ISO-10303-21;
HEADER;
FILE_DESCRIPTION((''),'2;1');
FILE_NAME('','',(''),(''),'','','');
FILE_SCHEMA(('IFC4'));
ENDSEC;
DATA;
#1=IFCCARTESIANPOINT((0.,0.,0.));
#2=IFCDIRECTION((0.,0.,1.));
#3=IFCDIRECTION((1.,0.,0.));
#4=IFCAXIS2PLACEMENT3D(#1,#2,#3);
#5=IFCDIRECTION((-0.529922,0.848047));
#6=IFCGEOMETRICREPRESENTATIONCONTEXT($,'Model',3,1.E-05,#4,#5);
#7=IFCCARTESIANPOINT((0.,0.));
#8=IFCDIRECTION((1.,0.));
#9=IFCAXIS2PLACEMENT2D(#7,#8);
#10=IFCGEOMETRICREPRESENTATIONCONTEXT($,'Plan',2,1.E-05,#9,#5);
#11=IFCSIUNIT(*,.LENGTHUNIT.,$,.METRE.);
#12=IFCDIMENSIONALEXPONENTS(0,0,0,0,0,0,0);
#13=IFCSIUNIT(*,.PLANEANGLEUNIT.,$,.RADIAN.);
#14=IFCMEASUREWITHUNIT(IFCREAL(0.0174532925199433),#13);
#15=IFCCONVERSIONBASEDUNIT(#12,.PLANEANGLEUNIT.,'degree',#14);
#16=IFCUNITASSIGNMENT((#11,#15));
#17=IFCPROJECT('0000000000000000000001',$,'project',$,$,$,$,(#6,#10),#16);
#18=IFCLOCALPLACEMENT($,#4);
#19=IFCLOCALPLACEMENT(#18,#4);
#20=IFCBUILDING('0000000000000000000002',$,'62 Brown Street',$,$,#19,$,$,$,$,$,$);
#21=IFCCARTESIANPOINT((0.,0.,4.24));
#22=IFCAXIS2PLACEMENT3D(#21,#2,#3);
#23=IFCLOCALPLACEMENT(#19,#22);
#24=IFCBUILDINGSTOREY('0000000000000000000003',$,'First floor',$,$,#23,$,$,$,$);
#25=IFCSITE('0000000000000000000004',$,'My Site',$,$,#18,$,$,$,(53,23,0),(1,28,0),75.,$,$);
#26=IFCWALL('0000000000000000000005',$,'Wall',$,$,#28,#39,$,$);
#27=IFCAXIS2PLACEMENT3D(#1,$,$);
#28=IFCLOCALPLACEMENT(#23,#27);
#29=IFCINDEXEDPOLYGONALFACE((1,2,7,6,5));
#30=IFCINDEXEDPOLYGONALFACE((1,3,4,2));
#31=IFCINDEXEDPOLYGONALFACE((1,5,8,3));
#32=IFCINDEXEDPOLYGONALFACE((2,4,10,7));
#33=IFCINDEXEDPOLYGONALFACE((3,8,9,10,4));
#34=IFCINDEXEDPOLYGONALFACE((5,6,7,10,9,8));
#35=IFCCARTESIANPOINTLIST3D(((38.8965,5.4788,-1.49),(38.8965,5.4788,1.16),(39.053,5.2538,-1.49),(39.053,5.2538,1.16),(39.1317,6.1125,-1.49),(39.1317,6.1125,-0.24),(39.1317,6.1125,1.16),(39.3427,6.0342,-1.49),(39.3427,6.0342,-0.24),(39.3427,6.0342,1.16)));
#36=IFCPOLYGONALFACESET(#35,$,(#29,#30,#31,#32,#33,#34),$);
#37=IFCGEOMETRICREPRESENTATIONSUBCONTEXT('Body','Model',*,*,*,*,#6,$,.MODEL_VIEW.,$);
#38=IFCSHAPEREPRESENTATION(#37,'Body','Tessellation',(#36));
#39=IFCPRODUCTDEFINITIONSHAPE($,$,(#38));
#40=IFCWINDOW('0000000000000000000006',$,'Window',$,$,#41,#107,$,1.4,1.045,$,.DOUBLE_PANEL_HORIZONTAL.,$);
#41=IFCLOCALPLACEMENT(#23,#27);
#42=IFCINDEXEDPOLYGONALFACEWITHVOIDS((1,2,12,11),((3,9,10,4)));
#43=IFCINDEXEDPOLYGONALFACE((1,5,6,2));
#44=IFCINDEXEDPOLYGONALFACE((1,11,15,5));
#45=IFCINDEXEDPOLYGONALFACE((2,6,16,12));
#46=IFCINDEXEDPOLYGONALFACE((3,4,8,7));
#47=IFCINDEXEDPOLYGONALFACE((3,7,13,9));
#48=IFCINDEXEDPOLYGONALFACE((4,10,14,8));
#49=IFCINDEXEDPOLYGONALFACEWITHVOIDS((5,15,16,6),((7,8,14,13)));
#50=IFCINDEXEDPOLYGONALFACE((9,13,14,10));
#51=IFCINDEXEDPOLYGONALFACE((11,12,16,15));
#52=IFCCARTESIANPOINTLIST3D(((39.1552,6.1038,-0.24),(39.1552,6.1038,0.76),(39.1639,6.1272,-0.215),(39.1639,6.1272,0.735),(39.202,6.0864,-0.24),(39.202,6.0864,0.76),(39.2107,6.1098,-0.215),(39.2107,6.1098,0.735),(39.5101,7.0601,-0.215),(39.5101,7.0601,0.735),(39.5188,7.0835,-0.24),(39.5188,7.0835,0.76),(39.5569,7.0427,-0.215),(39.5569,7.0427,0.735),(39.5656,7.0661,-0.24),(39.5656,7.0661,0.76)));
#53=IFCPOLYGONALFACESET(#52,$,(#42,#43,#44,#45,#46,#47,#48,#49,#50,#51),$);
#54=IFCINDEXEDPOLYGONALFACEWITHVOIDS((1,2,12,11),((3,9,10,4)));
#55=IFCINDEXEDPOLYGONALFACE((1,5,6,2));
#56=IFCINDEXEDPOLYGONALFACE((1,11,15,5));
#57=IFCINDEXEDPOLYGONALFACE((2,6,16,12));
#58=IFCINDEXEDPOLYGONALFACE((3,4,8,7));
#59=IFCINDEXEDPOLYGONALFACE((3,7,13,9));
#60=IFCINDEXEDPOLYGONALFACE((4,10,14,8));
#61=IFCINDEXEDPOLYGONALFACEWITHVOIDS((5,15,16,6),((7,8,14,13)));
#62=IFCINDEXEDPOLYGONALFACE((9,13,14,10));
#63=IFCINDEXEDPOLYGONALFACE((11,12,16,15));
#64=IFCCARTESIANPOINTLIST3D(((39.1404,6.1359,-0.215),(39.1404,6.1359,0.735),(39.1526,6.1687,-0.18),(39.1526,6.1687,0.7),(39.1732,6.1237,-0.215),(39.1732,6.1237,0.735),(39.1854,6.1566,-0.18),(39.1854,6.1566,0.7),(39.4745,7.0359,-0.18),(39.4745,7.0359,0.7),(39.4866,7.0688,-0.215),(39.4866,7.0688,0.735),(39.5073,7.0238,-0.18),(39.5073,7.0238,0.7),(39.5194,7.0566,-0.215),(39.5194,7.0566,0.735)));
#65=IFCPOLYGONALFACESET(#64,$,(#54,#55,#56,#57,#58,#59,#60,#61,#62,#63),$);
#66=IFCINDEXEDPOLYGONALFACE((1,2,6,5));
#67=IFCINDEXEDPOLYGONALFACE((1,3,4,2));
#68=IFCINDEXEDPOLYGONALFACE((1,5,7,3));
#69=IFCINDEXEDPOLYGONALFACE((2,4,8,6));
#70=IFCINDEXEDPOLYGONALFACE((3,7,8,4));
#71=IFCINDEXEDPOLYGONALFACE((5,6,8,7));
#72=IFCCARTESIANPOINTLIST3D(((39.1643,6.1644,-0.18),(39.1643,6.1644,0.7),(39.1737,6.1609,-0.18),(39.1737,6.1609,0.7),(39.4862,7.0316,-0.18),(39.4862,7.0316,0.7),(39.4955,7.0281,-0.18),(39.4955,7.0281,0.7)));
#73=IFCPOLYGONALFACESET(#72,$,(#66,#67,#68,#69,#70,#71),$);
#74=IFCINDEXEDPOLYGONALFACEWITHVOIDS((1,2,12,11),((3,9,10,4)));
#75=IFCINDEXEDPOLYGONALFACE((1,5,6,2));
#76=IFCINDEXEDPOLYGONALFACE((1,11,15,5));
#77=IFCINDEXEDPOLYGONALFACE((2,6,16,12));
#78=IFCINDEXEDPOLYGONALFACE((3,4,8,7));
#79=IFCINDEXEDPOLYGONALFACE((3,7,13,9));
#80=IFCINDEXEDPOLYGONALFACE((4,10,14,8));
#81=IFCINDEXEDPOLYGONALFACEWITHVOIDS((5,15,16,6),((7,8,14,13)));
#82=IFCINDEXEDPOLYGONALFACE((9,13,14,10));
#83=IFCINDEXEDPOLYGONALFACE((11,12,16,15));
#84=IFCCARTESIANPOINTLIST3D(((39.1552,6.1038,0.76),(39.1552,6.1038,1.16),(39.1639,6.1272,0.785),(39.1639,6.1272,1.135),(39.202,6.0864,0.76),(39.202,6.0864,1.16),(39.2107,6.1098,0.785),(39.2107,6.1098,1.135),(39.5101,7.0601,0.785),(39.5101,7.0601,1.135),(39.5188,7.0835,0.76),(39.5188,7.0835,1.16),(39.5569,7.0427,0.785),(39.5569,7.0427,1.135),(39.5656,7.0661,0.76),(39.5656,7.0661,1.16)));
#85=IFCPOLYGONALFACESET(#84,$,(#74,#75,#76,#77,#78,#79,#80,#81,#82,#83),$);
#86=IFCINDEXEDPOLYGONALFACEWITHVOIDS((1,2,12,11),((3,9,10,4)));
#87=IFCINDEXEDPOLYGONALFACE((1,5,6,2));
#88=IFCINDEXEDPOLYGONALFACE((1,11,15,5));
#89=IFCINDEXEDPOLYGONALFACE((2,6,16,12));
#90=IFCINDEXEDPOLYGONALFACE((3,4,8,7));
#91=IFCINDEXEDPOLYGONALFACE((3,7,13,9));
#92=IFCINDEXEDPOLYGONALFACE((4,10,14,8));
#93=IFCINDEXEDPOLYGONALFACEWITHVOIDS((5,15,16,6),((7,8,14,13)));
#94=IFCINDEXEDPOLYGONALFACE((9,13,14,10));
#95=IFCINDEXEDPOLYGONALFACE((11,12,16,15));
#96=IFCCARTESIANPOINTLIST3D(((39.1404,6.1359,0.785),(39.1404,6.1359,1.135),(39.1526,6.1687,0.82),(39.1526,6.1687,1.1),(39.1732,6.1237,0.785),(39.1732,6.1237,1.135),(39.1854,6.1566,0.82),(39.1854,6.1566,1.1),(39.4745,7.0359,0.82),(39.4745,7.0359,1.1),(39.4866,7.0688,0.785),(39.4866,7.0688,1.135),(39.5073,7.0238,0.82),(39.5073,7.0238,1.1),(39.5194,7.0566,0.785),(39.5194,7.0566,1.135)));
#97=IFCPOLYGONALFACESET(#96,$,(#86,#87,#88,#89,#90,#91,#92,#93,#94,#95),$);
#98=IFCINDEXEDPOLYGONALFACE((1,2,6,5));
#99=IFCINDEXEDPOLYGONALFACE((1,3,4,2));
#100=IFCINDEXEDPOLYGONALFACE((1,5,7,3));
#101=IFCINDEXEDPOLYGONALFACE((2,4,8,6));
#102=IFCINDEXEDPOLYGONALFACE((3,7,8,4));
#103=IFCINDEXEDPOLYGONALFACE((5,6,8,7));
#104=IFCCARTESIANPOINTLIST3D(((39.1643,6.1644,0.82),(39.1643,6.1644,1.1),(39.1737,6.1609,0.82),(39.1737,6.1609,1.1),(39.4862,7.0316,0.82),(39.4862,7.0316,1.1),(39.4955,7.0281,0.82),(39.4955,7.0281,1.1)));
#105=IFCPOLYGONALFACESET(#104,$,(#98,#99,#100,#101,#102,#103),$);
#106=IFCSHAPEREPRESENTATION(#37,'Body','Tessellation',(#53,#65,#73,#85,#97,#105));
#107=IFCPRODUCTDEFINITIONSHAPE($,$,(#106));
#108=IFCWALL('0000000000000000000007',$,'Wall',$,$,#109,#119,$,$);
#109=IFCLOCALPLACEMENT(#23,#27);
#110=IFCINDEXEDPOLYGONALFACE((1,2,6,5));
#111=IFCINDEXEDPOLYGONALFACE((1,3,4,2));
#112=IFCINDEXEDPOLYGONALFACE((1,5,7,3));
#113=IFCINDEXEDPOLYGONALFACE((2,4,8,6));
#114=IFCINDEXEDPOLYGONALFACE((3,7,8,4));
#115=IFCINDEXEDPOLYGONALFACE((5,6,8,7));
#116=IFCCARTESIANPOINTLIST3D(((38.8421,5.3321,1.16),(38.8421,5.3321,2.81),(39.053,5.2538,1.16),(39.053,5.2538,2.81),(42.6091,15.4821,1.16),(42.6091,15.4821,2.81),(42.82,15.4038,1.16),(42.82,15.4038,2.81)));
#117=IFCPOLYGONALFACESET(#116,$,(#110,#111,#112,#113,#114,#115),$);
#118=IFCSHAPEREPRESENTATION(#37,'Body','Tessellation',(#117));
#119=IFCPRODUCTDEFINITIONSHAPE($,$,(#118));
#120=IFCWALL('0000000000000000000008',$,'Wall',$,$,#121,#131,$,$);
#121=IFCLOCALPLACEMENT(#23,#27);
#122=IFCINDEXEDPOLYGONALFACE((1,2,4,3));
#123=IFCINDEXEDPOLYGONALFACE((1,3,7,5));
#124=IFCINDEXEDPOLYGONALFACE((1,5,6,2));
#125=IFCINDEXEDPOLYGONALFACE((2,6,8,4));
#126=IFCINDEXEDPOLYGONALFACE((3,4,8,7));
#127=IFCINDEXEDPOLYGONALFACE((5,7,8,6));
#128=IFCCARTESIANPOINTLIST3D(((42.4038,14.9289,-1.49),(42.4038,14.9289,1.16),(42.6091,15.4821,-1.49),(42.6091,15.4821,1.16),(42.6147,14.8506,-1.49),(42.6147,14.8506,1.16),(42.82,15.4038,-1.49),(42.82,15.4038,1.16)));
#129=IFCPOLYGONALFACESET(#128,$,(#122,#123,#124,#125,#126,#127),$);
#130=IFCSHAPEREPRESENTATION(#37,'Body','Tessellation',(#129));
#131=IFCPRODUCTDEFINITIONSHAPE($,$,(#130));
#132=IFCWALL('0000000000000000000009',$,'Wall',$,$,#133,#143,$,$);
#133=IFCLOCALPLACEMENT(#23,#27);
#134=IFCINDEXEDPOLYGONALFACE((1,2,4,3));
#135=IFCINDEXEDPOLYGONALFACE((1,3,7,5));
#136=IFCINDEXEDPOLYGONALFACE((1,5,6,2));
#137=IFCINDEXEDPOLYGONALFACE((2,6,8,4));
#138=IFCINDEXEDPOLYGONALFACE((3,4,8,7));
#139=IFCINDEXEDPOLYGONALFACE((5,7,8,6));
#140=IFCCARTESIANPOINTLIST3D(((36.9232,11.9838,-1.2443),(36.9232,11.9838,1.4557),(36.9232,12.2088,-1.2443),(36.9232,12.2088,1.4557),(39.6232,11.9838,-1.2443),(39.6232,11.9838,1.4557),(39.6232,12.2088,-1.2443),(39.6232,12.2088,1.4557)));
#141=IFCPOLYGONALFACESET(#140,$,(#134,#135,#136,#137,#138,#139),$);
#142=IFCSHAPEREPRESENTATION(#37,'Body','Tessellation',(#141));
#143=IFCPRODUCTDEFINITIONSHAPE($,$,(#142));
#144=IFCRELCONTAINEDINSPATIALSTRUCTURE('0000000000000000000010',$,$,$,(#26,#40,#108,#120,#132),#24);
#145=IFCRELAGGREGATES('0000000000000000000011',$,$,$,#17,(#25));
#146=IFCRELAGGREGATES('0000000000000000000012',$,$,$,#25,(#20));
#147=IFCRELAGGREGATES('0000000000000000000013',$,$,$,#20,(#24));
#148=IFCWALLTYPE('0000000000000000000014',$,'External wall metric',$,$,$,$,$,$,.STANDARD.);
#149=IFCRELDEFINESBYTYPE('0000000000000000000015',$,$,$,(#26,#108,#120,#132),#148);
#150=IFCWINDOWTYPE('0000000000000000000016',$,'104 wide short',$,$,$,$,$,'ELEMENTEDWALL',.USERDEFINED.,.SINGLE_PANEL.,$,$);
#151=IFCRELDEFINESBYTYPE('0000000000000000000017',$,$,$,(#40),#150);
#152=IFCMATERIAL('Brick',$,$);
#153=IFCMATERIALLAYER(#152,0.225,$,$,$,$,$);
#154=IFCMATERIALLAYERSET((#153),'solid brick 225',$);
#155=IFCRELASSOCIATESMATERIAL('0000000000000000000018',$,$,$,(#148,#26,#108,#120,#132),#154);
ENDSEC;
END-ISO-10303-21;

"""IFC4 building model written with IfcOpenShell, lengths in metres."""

from ifc_helpers import new_model, entity, si_unit, converted_unit, direction, frame, origin_with_axes, origin_2d_with_axis, place, context, subcontext, project, spatial, line, indexed_curve, outline, extrude, clip, halfspace, shape, source, transform, mapped, material, layer, layer_set, layer_usage, type_object, type_shapes, element, fill, save


model = new_model("IFC4")

# Units and contexts
model_context = context("Model", 3, precision=1e-05, world=origin_with_axes(), true_north=direction((-0.529922, 0.848047)))
plan_context = context("Plan", 2, precision=1e-05, world=origin_2d_with_axis(), true_north=direction((-0.529922, 0.848047)))
body_context_1 = subcontext(model_context, "Body", "Model", "MODEL_VIEW")
body_context_2 = subcontext(plan_context, "Body", "Plan", "PLAN_VIEW")
ifc_project = project(units=[si_unit("LENGTHUNIT", "METRE"), converted_unit("PLANEANGLEUNIT", "degree", entity("IfcReal", 0.0174532925199433), si_unit("PLANEANGLEUNIT", "RADIAN"), dimensions=[0, 0, 0, 0, 0, 0, 0])], contexts=[model_context, plan_context])

# Site, building, storey
site_placement = place(None, origin_with_axes())
site = spatial("IfcSite", under=ifc_project, at=site_placement, Name="My Site", RefLatitude=(53, 23, 0), RefLongitude=(1, 28, 0), RefElevation=75.0)
building_placement = place(site_placement, origin_with_axes())
building = spatial("IfcBuilding", under=site, at=building_placement, Name="62 Brown Street")
storey_placement = place(building_placement, frame((0.0, 0.0, 4.24), z_axis=(0.0, 0.0, 1.0), x_axis=(1.0, 0.0, 0.0)))
storey = spatial("IfcBuildingStorey", under=building, at=storey_placement, Name="First floor")

# Wall, opening, window
ifc_material_1 = material(Name="Brick")
ifc_layer_1 = layer(ifc_material_1, 0.225)
ifc_layer_set_1 = layer_set([ifc_layer_1], Name="solid brick 225")
ifc_layer_usage_1 = layer_usage(ifc_layer_set_1, "AXIS2", "POSITIVE", 0.0)
wall_type_1 = type_object("IfcWallType", Name="External wall metric", PredefinedType="STANDARD", material=ifc_layer_set_1)
wall_1_placement = place(storey_placement, frame((39.024, 5.1755, -1.49), z_axis=(0.0, 0.0, 1.0), x_axis=(0.347944, 0.937515, 0.0)))
wall_1 = element("IfcWall", 1, at=wall_1_placement, inside=storey, type_object=wall_type_1, material=ifc_layer_usage_1, Name="Wall", context=body_context_1, shape_type="Clipping", body=[
    clip(extrude(outline(indexed_curve([(0.0, 0.0), (0.0, 0.225), (0.9159, 0.225), (0.9159, 0.0), (0.0, 0.0)], self_intersect=False)), origin_with_axes(), (0.0, 0.0, 1.0), 2.65), halfspace(frame((0.0835, 0.0, -2.75), z_axis=(-0.596248, 0.414701, 0.0), x_axis=(0.156491, 0.224999, 0.0)), False)),
])
shared_shape_1 = source(origin_with_axes(), body_context_1, "Body", "SweptSolid", [
    extrude(outline(indexed_curve([(0.0, 0.0), (1.045, 0.0), (1.045, 1.4), (0.0, 1.4)], segments=[line(1, 2, 3, 4, 1)])), frame((0.0, -0.1, 0.0), z_axis=(0.0, -1.0, 0.0), x_axis=(1.0, 0.0, 0.0)), (0.0, 0.0, -1.0), 0.425),
])
opening_placement = place(wall_1_placement, frame((0.9159, 0.0, 1.25), z_axis=(0.0, 0.0, 1.0), x_axis=(1.0, 0.0, 0.0)))
opening = element("IfcOpeningElement", 2, at=opening_placement, cuts=wall_1, PredefinedType="OPENING", context=body_context_1, shape_type="MappedRepresentation", body=[
    mapped(shared_shape_1, transform((0.0, 0.0, 0.0), x_axis=(1.0, 0.0, 0.0), y_axis=(0.0, 1.0, 0.0), z_axis=(0.0, 0.0, 1.0), scale=1.0)),
])
window_type = type_object("IfcWindowType", Name="104 wide short", ElementType="ELEMENTEDWALL", PartitioningType="SINGLE_PANEL", PredefinedType="USERDEFINED")
shared_shape_2 = source(origin_with_axes(), body_context_1, "Body", "SweptSolid", [
    extrude(outline(indexed_curve([(0.0, 0.0), (1.045, 0.0), (1.045, 1.0), (0.0, 1.0)], segments=[line(1, 2, 3, 4, 1)]), holes=[indexed_curve([(0.025, 0.025), (1.02, 0.025), (1.02, 0.975), (0.025, 0.975)], segments=[line(1, 2, 3, 4, 1)])]), frame((0.0, 0.15, 0.0), z_axis=(0.0, -1.0, 0.0), x_axis=(1.0, 0.0, 0.0)), (0.0, 0.0, -1.0), 0.05),
    extrude(outline(indexed_curve([(0.0, 0.0), (0.995, 0.0), (0.995, 0.95), (0.0, 0.95)], segments=[line(1, 2, 3, 4, 1)]), holes=[indexed_curve([(0.035, 0.035), (0.96, 0.035), (0.96, 0.915), (0.035, 0.915)], segments=[line(1, 2, 3, 4, 1)])]), frame((0.025, 0.19, 0.025), z_axis=(0.0, -1.0, 0.0), x_axis=(1.0, 0.0, 0.0)), (0.0, 0.0, -1.0), 0.035),
    extrude(outline(indexed_curve([(0.035, 0.035), (0.96, 0.035), (0.96, 0.915), (0.035, 0.915)], segments=[line(1, 2, 3, 4, 1)])), frame((0.025, 0.2025, 0.025), z_axis=(0.0, -1.0, 0.0), x_axis=(1.0, 0.0, 0.0)), (0.0, 0.0, -1.0), 0.01),
    extrude(outline(indexed_curve([(0.0, 0.0), (1.045, 0.0), (1.045, 0.4), (0.0, 0.4)], segments=[line(1, 2, 3, 4, 1)]), holes=[indexed_curve([(0.025, 0.025), (1.02, 0.025), (1.02, 0.375), (0.025, 0.375)], segments=[line(1, 2, 3, 4, 1)])]), frame((0.0, 0.15, 1.0), z_axis=(0.0, -1.0, 0.0), x_axis=(1.0, 0.0, 0.0)), (0.0, 0.0, -1.0), 0.05),
    extrude(outline(indexed_curve([(0.0, 0.0), (0.995, 0.0), (0.995, 0.35), (0.0, 0.35)], segments=[line(1, 2, 3, 4, 1)]), holes=[indexed_curve([(0.035, 0.035), (0.96, 0.035), (0.96, 0.315), (0.035, 0.315)], segments=[line(1, 2, 3, 4, 1)])]), frame((0.025, 0.19, 1.025), z_axis=(0.0, -1.0, 0.0), x_axis=(1.0, 0.0, 0.0)), (0.0, 0.0, -1.0), 0.035),
    extrude(outline(indexed_curve([(0.035, 0.035), (0.96, 0.035), (0.96, 0.315), (0.035, 0.315)], segments=[line(1, 2, 3, 4, 1)])), frame((0.025, 0.2025, 1.025), z_axis=(0.0, -1.0, 0.0), x_axis=(1.0, 0.0, 0.0)), (0.0, 0.0, -1.0), 0.01),
])
shared_shape_3 = source(origin_with_axes(), body_context_2, "Body", "Curve2D", [
    entity("IfcIndexedPolyCurve", entity("IfcCartesianPointList2D", [[0.025, 0.15], [1.02, 0.15]])),
    entity("IfcIndexedPolyCurve", entity("IfcCartesianPointList2D", [[0.0, 0.2], [0.025, 0.2], [0.025, 0.15], [0.0, 0.15]]), [entity("IfcLineIndex", [1, 2, 3, 4, 1])]),
    entity("IfcIndexedPolyCurve", entity("IfcCartesianPointList2D", [[1.045, 0.2], [1.02, 0.2], [1.02, 0.15], [1.045, 0.15]]), [entity("IfcLineIndex", [1, 2, 3, 4, 1])]),
    entity("IfcIndexedPolyCurve", entity("IfcCartesianPointList2D", [[0.025, 0.19], [0.06, 0.19], [0.06, 0.225], [0.025, 0.225]]), [entity("IfcLineIndex", [1, 2, 3, 4, 1])]),
    entity("IfcIndexedPolyCurve", entity("IfcCartesianPointList2D", [[1.02, 0.19], [0.985, 0.19], [0.985, 0.225], [1.02, 0.225]]), [entity("IfcLineIndex", [1, 2, 3, 4, 1])]),
    entity("IfcIndexedPolyCurve", entity("IfcCartesianPointList2D", [[0.06, 0.19], [0.985, 0.19]])),
    entity("IfcIndexedPolyCurve", entity("IfcCartesianPointList2D", [[0.06, 0.225], [0.985, 0.225]])),
    entity("IfcIndexedPolyCurve", entity("IfcCartesianPointList2D", [[0.06, 0.2075], [0.985, 0.2075]])),
])
type_shapes(window_type, [shared_shape_2, shared_shape_3])
window_1_placement = place(opening_placement, frame((0.0, 0.0, 0.0), z_axis=(0.0, 0.0, 1.0), x_axis=(1.0, 0.0, 0.0)))
window_1 = element("IfcWindow", 3, at=window_1_placement, inside=storey, type_object=window_type, Name="Window", OverallHeight=1.4, OverallWidth=1.045, PartitioningType="DOUBLE_PANEL_HORIZONTAL", shapes=[
    shape(body_context_1, "Body", "MappedRepresentation", [mapped(shared_shape_2, transform((0.0, 0.0, 0.0), x_axis=(1.0, 0.0, 0.0), y_axis=(0.0, 1.0, 0.0), z_axis=(0.0, 0.0, 1.0), scale=1.0))]),
    shape(body_context_2, "Body", "MappedRepresentation", [mapped(shared_shape_3, transform((0.0, 0.0, 0.0), x_axis=(1.0, 0.0, 0.0), y_axis=(0.0, 1.0, 0.0), z_axis=(0.0, 0.0, 1.0), scale=1.0))]),
])
fill(opening, window_1)

# Walls
ifc_layer_usage_2 = layer_usage(ifc_layer_set_1, "AXIS2", "POSITIVE", 0.0)
wall_2_placement = place(storey_placement, frame((39.053, 5.2538, 1.16), z_axis=(0.0, 0.0, 1.0), x_axis=(0.347944, 0.937515, 0.0)))
element("IfcWall", 4, at=wall_2_placement, inside=storey, type_object=wall_type_1, material=ifc_layer_usage_2, Name="Wall", context=body_context_1, shape_type="SweptSolid", body=[
    extrude(outline(indexed_curve([(0.0, 0.0), (0.0, 0.225), (10.8265, 0.225), (10.8265, 0.0), (0.0, 0.0)], self_intersect=False)), origin_with_axes(), (0.0, 0.0, 1.0), 1.65),
])
ifc_layer_usage_3 = layer_usage(ifc_layer_set_1, "AXIS2", "POSITIVE", 0.0)
wall_3_placement = place(storey_placement, frame((42.6147, 14.8506, -1.49), z_axis=(0.0, 0.0, 1.0), x_axis=(0.347944, 0.937515, 0.0)))
element("IfcWall", 5, at=wall_3_placement, inside=storey, type_object=wall_type_1, material=ifc_layer_usage_3, Name="Wall", context=body_context_1, shape_type="SweptSolid", body=[
    extrude(outline(indexed_curve([(0.0, 0.0), (0.0, 0.225), (0.5901, 0.225), (0.5901, 0.0), (0.0, 0.0)], self_intersect=False)), origin_with_axes(), (0.0, 0.0, 1.0), 2.65),
])
ifc_layer_usage_4 = layer_usage(ifc_layer_set_1, "AXIS2", "POSITIVE", 0.0)
wall_4_placement = place(storey_placement, frame((36.9232, 11.9838, -1.2443), z_axis=(0.0, 0.0, 1.0), x_axis=(1.0, 0.0, 0.0)))
element("IfcWall", 6, at=wall_4_placement, inside=storey, type_object=wall_type_1, material=ifc_layer_usage_4, Name="Wall", context=body_context_1, shape_type="SweptSolid", body=[
    extrude(outline(indexed_curve([(0.0, 0.0), (0.0, 0.225), (2.7, 0.225), (2.7, 0.0), (0.0, 0.0)], self_intersect=False)), origin_with_axes(), (0.0, 0.0, 1.0), 2.7),
])

save(model, "model.ifc")
